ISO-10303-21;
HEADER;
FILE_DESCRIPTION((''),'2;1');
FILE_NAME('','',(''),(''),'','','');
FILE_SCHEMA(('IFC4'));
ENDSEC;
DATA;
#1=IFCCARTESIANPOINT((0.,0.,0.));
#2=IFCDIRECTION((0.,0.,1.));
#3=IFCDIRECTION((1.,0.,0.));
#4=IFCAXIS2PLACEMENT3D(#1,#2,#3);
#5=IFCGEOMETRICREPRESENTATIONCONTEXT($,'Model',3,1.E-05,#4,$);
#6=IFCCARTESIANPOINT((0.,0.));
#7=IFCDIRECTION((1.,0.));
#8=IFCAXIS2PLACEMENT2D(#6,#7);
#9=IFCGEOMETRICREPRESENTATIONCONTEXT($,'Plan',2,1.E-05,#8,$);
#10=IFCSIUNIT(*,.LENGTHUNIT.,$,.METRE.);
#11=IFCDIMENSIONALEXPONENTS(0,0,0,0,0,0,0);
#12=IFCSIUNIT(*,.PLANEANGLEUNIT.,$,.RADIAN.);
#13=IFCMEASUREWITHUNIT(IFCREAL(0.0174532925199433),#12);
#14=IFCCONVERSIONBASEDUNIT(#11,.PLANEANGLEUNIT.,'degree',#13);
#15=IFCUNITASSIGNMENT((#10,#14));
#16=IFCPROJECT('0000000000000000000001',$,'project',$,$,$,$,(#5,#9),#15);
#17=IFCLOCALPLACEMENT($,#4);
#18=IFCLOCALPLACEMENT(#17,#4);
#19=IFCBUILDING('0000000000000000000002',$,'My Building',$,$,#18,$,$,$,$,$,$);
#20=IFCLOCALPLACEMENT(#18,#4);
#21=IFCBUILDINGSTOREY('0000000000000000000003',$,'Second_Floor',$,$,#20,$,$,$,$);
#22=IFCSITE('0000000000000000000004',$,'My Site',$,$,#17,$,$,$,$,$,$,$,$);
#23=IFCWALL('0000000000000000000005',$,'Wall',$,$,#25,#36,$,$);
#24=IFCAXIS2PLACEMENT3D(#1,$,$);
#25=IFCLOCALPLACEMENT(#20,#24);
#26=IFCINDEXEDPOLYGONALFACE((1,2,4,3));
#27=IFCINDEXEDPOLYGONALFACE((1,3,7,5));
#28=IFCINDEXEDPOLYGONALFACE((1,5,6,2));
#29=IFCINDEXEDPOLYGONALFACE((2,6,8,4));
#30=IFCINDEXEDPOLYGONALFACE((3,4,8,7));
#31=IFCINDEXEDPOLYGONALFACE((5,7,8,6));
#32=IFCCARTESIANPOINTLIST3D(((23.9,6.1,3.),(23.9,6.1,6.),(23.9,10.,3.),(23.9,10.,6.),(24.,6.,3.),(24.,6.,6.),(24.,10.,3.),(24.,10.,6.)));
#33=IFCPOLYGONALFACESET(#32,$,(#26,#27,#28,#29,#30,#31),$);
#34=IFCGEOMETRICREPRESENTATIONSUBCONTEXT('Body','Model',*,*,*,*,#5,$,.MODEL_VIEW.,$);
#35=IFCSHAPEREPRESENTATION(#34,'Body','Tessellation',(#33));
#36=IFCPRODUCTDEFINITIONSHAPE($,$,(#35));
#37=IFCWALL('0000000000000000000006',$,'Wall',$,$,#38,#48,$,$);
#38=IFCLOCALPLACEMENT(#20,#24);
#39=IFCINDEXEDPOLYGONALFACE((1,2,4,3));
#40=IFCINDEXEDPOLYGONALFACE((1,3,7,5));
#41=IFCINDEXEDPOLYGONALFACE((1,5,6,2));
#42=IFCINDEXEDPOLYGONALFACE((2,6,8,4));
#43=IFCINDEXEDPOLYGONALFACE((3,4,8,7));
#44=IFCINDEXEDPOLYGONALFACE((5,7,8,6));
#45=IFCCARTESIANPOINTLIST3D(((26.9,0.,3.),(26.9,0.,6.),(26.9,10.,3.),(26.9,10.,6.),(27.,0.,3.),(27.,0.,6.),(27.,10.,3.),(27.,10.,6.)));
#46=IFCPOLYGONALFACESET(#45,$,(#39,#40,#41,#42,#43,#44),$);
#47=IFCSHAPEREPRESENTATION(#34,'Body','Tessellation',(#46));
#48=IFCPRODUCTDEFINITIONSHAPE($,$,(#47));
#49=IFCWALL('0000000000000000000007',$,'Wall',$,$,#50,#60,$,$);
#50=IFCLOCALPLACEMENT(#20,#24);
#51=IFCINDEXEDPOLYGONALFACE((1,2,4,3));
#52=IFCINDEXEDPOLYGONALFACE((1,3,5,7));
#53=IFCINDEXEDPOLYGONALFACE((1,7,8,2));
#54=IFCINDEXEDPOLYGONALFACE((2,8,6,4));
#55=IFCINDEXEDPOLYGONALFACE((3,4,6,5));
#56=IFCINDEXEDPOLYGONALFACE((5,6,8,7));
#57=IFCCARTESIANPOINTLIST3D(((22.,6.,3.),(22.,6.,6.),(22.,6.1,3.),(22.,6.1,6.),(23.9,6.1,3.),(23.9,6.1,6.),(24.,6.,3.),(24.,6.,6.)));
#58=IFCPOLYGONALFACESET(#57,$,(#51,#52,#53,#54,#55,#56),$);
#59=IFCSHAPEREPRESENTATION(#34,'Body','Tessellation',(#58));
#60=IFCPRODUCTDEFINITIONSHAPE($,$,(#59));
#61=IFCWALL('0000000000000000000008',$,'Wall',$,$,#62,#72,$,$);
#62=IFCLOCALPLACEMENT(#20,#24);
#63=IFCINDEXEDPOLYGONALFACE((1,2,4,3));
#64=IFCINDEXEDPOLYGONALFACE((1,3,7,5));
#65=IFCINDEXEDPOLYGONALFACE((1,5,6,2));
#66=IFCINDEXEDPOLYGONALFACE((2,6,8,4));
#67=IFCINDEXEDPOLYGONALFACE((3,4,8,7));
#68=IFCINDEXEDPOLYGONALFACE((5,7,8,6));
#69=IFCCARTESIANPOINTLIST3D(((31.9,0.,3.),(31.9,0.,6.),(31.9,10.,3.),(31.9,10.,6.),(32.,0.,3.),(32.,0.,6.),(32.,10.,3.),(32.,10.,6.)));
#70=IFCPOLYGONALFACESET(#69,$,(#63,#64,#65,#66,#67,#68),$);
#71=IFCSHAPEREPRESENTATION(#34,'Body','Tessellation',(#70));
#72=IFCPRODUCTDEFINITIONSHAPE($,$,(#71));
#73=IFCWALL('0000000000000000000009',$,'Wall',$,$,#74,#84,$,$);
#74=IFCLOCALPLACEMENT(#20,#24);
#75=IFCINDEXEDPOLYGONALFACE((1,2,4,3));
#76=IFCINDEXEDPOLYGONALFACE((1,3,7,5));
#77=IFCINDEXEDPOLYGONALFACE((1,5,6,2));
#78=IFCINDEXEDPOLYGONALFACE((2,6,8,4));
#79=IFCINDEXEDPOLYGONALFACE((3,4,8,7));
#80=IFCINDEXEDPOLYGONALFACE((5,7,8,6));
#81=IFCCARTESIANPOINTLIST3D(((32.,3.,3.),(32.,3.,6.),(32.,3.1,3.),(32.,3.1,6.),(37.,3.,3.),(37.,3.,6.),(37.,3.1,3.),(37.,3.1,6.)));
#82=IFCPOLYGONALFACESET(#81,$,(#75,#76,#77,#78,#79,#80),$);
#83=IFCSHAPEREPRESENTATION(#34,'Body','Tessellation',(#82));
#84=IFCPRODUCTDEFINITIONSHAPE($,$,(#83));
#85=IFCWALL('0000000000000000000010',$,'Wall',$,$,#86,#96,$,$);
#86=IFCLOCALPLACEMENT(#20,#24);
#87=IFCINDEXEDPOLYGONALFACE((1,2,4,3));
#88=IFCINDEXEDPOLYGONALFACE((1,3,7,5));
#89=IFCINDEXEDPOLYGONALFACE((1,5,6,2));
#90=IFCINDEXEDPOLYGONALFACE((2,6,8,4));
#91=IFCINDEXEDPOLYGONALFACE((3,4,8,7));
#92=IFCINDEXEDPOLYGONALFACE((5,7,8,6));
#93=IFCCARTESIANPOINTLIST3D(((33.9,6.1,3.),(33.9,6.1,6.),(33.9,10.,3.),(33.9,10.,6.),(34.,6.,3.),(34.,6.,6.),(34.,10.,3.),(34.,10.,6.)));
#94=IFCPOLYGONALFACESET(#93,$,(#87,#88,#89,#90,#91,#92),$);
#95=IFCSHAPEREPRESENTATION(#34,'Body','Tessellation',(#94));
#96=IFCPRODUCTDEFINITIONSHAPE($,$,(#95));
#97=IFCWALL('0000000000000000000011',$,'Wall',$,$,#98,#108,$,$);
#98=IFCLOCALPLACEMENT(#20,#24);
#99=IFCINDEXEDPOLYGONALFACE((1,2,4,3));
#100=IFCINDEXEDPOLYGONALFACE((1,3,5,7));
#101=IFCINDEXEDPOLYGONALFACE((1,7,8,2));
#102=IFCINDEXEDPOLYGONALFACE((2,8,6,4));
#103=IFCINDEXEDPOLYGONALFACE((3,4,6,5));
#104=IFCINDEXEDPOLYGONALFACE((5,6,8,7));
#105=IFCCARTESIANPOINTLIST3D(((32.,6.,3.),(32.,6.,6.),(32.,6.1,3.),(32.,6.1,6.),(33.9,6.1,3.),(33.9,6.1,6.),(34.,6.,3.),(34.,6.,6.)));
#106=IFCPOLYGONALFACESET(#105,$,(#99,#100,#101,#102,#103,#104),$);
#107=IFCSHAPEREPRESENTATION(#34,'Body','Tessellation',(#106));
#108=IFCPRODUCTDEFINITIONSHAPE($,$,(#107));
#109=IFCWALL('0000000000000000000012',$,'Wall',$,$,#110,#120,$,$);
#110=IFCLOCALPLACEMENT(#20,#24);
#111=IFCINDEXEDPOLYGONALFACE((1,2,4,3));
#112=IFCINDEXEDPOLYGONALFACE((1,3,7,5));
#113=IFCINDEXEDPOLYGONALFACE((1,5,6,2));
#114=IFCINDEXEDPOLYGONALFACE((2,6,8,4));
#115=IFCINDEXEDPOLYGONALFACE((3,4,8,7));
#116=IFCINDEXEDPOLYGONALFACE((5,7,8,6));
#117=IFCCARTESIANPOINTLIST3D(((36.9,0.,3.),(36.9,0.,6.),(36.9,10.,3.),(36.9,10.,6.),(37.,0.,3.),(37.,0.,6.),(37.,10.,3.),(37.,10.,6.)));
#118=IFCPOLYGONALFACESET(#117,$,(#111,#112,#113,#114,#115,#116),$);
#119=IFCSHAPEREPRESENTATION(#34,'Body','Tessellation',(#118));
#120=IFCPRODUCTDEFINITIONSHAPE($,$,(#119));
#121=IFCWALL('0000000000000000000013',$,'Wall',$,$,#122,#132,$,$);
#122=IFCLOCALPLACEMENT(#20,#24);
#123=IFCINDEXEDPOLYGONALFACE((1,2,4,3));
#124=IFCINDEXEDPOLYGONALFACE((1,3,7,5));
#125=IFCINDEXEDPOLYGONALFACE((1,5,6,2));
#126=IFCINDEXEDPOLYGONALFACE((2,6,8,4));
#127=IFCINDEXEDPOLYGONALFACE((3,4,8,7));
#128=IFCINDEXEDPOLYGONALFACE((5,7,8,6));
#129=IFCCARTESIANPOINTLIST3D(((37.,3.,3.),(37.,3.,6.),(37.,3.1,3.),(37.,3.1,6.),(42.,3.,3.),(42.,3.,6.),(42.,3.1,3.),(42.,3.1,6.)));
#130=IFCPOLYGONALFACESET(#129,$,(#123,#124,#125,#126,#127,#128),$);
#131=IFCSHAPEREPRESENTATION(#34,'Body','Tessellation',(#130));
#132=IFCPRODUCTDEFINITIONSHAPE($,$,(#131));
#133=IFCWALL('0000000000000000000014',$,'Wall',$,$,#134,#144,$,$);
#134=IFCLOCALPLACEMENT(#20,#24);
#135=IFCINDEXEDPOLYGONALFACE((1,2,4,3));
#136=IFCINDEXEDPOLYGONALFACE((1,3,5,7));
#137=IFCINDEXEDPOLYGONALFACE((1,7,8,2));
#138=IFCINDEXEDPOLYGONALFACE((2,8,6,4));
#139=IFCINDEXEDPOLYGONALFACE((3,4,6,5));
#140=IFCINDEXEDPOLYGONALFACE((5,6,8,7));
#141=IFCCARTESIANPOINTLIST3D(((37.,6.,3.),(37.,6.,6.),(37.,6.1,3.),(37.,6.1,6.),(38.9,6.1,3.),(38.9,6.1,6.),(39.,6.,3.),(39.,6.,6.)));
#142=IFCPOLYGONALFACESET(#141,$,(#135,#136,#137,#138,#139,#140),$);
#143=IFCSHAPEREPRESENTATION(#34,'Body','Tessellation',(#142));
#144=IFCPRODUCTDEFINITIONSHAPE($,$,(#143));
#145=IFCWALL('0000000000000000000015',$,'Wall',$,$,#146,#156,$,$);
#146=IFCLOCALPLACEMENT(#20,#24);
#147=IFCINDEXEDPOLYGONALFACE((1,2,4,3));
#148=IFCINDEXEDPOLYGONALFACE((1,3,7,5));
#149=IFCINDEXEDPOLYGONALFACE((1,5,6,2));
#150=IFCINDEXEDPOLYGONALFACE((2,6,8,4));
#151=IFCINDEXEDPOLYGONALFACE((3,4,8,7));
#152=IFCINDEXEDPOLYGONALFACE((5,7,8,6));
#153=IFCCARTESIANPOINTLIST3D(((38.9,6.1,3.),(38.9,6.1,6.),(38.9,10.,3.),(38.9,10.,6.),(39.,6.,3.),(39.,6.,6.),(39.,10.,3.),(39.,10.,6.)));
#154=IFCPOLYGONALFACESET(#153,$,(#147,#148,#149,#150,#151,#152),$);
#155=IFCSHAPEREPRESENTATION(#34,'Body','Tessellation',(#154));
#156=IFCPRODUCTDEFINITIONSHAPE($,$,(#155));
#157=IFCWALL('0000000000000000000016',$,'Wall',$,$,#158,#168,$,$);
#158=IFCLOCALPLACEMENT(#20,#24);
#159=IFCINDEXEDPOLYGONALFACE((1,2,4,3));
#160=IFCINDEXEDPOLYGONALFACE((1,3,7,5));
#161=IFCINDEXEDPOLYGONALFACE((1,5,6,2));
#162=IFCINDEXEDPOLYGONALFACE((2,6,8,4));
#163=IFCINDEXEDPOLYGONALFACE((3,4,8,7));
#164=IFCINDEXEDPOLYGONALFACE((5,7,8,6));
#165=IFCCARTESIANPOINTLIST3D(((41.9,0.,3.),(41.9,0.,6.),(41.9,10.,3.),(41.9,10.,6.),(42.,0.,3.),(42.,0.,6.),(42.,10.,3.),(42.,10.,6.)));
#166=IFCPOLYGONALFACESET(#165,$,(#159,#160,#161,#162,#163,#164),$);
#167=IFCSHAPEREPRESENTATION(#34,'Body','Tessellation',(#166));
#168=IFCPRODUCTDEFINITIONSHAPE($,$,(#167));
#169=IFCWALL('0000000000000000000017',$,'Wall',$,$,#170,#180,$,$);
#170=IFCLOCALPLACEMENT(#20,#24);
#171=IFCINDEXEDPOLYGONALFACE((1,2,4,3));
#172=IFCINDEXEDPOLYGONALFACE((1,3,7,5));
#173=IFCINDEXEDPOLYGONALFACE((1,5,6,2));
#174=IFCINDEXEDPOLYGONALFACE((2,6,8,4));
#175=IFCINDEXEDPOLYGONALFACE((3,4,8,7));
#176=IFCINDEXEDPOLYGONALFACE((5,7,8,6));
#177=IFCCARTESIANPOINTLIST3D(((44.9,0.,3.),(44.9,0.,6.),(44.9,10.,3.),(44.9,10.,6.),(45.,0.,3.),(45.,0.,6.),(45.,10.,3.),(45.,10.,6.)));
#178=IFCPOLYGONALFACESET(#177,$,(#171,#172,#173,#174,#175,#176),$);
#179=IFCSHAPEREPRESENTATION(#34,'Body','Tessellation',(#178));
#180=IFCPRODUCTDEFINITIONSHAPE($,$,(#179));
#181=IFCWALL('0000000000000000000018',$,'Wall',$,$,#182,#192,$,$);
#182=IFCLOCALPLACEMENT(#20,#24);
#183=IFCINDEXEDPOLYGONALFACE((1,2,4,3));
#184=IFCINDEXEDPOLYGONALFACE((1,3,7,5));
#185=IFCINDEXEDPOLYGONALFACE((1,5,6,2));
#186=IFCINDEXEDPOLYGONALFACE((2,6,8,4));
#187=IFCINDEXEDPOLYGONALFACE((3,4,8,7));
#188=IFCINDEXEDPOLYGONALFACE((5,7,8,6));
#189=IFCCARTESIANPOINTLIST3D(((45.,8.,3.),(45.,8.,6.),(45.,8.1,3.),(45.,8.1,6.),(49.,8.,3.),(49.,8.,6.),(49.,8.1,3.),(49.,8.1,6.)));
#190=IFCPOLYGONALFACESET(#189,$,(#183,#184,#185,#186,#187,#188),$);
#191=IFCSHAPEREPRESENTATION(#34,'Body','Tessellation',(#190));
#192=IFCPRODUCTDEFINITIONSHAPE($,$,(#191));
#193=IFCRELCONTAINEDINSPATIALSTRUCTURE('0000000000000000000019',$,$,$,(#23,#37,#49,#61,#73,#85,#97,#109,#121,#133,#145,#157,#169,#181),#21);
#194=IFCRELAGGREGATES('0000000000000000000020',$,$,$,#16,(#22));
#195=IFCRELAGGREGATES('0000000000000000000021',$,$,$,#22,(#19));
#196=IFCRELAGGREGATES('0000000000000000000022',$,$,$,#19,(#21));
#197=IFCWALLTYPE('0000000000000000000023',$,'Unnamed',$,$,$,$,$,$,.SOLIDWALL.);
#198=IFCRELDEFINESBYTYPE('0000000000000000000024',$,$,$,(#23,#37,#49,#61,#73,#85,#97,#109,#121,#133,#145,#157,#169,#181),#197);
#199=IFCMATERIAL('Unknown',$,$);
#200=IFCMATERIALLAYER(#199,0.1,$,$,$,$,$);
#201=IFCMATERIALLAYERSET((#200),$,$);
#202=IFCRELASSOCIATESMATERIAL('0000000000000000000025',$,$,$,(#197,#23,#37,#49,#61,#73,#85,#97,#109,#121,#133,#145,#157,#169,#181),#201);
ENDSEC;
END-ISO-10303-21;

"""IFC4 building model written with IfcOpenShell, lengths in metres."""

from ifc_helpers import new_model, entity, si_unit, converted_unit, frame, origin_with_axes, origin_2d_with_axis, place, context, subcontext, project, spatial, line, indexed_curve, outline, extrude, material, layer, layer_set, layer_usage, type_object, element, save


model = new_model("IFC4")

# Units and contexts
model_context = context("Model", 3, precision=1e-05, world=origin_with_axes())
plan_context = context("Plan", 2, precision=1e-05, world=origin_2d_with_axis())
body_context = subcontext(model_context, "Body", "Model", "MODEL_VIEW")
ifc_project = project(units=[si_unit("LENGTHUNIT", "METRE"), converted_unit("PLANEANGLEUNIT", "degree", entity("IfcReal", 0.0174532925199433), si_unit("PLANEANGLEUNIT", "RADIAN"), dimensions=[0, 0, 0, 0, 0, 0, 0])], contexts=[model_context, plan_context])

# Site, building, storey
site_placement = place(None, origin_with_axes())
site = spatial("IfcSite", under=ifc_project, at=site_placement, Name="My Site")
building_placement = place(site_placement, origin_with_axes())
building = spatial("IfcBuilding", under=site, at=building_placement, Name="My Building")
storey_placement = place(building_placement, origin_with_axes())
storey = spatial("IfcBuildingStorey", under=building, at=storey_placement, Name="Second_Floor")

# Walls
ifc_material = material(Name="Unknown")
ifc_layer = layer(ifc_material, 0.1)
ifc_layer_set = layer_set([ifc_layer])
ifc_layer_usage_1 = layer_usage(ifc_layer_set, "AXIS2", "POSITIVE", 0.0)
wall_type = type_object("IfcWallType", Name="Unnamed", PredefinedType="SOLIDWALL", material=ifc_layer_set)
wall_1_placement = place(storey_placement, frame((24.0, 6.0, 3.0), z_axis=(0.0, 0.0, 1.0), x_axis=(0.0, 1.0, 0.0)))
element("IfcWall", 1, at=wall_1_placement, inside=storey, type_object=wall_type, material=ifc_layer_usage_1, Name="Wall", context=body_context, shape_type="SweptSolid", body=[
    extrude(outline(indexed_curve([(0.0, 0.0), (0.1, 0.1), (4.0, 0.1), (4.0, 0.0)], segments=[line(1, 2, 3, 4, 1)])), origin_with_axes(), (0.0, 0.0, 1.0), 3.0),
])
ifc_layer_usage_2 = layer_usage(ifc_layer_set, "AXIS2", "POSITIVE", 0.0)
wall_2_placement = place(storey_placement, frame((26.9, 10.0, 3.0), z_axis=(0.0, 0.0, 1.0), x_axis=(0.0, -1.0, 0.0)))
element("IfcWall", 2, at=wall_2_placement, inside=storey, type_object=wall_type, material=ifc_layer_usage_2, Name="Wall", context=body_context, shape_type="SweptSolid", body=[
    extrude(outline(indexed_curve([(0.0, 0.0), (0.0, 0.1), (10.0, 0.1), (10.0, 0.0)], segments=[line(1, 2, 3, 4, 1)])), origin_with_axes(), (0.0, 0.0, 1.0), 3.0),
])
ifc_layer_usage_3 = layer_usage(ifc_layer_set, "AXIS2", "POSITIVE", 0.0)
wall_3_placement = place(storey_placement, frame((22.0, 6.0, 3.0), z_axis=(0.0, 0.0, 1.0), x_axis=(1.0, 0.0, 0.0)))
element("IfcWall", 3, at=wall_3_placement, inside=storey, type_object=wall_type, material=ifc_layer_usage_3, Name="Wall", context=body_context, shape_type="SweptSolid", body=[
    extrude(outline(indexed_curve([(0.0, 0.0), (0.0, 0.1), (1.9, 0.1), (2.0, 0.0)], segments=[line(1, 2, 3, 4, 1)])), origin_with_axes(), (0.0, 0.0, 1.0), 3.0),
])
ifc_layer_usage_4 = layer_usage(ifc_layer_set, "AXIS2", "POSITIVE", 0.0)
wall_4_placement = place(storey_placement, frame((31.9, 10.0, 3.0), z_axis=(0.0, 0.0, 1.0), x_axis=(0.0, -1.0, 0.0)))
element("IfcWall", 4, at=wall_4_placement, inside=storey, type_object=wall_type, material=ifc_layer_usage_4, Name="Wall", context=body_context, shape_type="SweptSolid", body=[
    extrude(outline(indexed_curve([(0.0, 0.0), (0.0, 0.1), (10.0, 0.1), (10.0, 0.0)], segments=[line(1, 2, 3, 4, 1)])), origin_with_axes(), (0.0, 0.0, 1.0), 3.0),
])
ifc_layer_usage_5 = layer_usage(ifc_layer_set, "AXIS2", "POSITIVE", 0.0)
wall_5_placement = place(storey_placement, frame((32.0, 3.0, 3.0), z_axis=(0.0, 0.0, 1.0), x_axis=(1.0, 0.0, 0.0)))
element("IfcWall", 5, at=wall_5_placement, inside=storey, type_object=wall_type, material=ifc_layer_usage_5, Name="Wall", context=body_context, shape_type="SweptSolid", body=[
    extrude(outline(indexed_curve([(0.0, 0.0), (0.0, 0.1), (5.0, 0.1), (5.0, 0.0)], segments=[line(1, 2, 3, 4, 1)])), origin_with_axes(), (0.0, 0.0, 1.0), 3.0),
])
ifc_layer_usage_6 = layer_usage(ifc_layer_set, "AXIS2", "POSITIVE", 0.0)
wall_6_placement = place(storey_placement, frame((34.0, 6.0, 3.0), z_axis=(0.0, 0.0, 1.0), x_axis=(0.0, 1.0, 0.0)))
element("IfcWall", 6, at=wall_6_placement, inside=storey, type_object=wall_type, material=ifc_layer_usage_6, Name="Wall", context=body_context, shape_type="SweptSolid", body=[
    extrude(outline(indexed_curve([(0.0, 0.0), (0.1, 0.1), (4.0, 0.1), (4.0, 0.0)], segments=[line(1, 2, 3, 4, 1)])), origin_with_axes(), (0.0, 0.0, 1.0), 3.0),
])
ifc_layer_usage_7 = layer_usage(ifc_layer_set, "AXIS2", "POSITIVE", 0.0)
wall_7_placement = place(storey_placement, frame((32.0, 6.0, 3.0), z_axis=(0.0, 0.0, 1.0), x_axis=(1.0, 0.0, 0.0)))
element("IfcWall", 7, at=wall_7_placement, inside=storey, type_object=wall_type, material=ifc_layer_usage_7, Name="Wall", context=body_context, shape_type="SweptSolid", body=[
    extrude(outline(indexed_curve([(0.0, 0.0), (0.0, 0.1), (1.9, 0.1), (2.0, 0.0)], segments=[line(1, 2, 3, 4, 1)])), origin_with_axes(), (0.0, 0.0, 1.0), 3.0),
])
ifc_layer_usage_8 = layer_usage(ifc_layer_set, "AXIS2", "POSITIVE", 0.0)
wall_8_placement = place(storey_placement, frame((36.9, 10.0, 3.0), z_axis=(0.0, 0.0, 1.0), x_axis=(0.0, -1.0, 0.0)))
element("IfcWall", 8, at=wall_8_placement, inside=storey, type_object=wall_type, material=ifc_layer_usage_8, Name="Wall", context=body_context, shape_type="SweptSolid", body=[
    extrude(outline(indexed_curve([(0.0, 0.0), (0.0, 0.1), (10.0, 0.1), (10.0, 0.0)], segments=[line(1, 2, 3, 4, 1)])), origin_with_axes(), (0.0, 0.0, 1.0), 3.0),
])
ifc_layer_usage_9 = layer_usage(ifc_layer_set, "AXIS2", "POSITIVE", 0.0)
wall_9_placement = place(storey_placement, frame((37.0, 3.0, 3.0), z_axis=(0.0, 0.0, 1.0), x_axis=(1.0, 0.0, 0.0)))
element("IfcWall", 9, at=wall_9_placement, inside=storey, type_object=wall_type, material=ifc_layer_usage_9, Name="Wall", context=body_context, shape_type="SweptSolid", body=[
    extrude(outline(indexed_curve([(0.0, 0.0), (0.0, 0.1), (5.0, 0.1), (5.0, 0.0)], segments=[line(1, 2, 3, 4, 1)])), origin_with_axes(), (0.0, 0.0, 1.0), 3.0),
])
ifc_layer_usage_10 = layer_usage(ifc_layer_set, "AXIS2", "POSITIVE", 0.0)
wall_10_placement = place(storey_placement, frame((37.0, 6.0, 3.0), z_axis=(0.0, 0.0, 1.0), x_axis=(1.0, 0.0, 0.0)))
element("IfcWall", 10, at=wall_10_placement, inside=storey, type_object=wall_type, material=ifc_layer_usage_10, Name="Wall", context=body_context, shape_type="SweptSolid", body=[
    extrude(outline(indexed_curve([(0.0, 0.0), (0.0, 0.1), (1.9, 0.1), (2.0, 0.0)], segments=[line(1, 2, 3, 4, 1)])), origin_with_axes(), (0.0, 0.0, 1.0), 3.0),
])
ifc_layer_usage_11 = layer_usage(ifc_layer_set, "AXIS2", "POSITIVE", 0.0)
wall_11_placement = place(storey_placement, frame((39.0, 6.0, 3.0), z_axis=(0.0, 0.0, 1.0), x_axis=(0.0, 1.0, 0.0)))
element("IfcWall", 11, at=wall_11_placement, inside=storey, type_object=wall_type, material=ifc_layer_usage_11, Name="Wall", context=body_context, shape_type="SweptSolid", body=[
    extrude(outline(indexed_curve([(0.0, 0.0), (0.1, 0.1), (4.0, 0.1), (4.0, 0.0)], segments=[line(1, 2, 3, 4, 1)])), origin_with_axes(), (0.0, 0.0, 1.0), 3.0),
])
ifc_layer_usage_12 = layer_usage(ifc_layer_set, "AXIS2", "POSITIVE", 0.0)
wall_12_placement = place(storey_placement, frame((41.9, 10.0, 3.0), z_axis=(0.0, 0.0, 1.0), x_axis=(0.0, -1.0, 0.0)))
element("IfcWall", 12, at=wall_12_placement, inside=storey, type_object=wall_type, material=ifc_layer_usage_12, Name="Wall", context=body_context, shape_type="SweptSolid", body=[
    extrude(outline(indexed_curve([(0.0, 0.0), (0.0, 0.1), (10.0, 0.1), (10.0, 0.0)], segments=[line(1, 2, 3, 4, 1)])), origin_with_axes(), (0.0, 0.0, 1.0), 3.0),
])
ifc_layer_usage_13 = layer_usage(ifc_layer_set, "AXIS2", "POSITIVE", 0.0)
wall_13_placement = place(storey_placement, frame((44.9, 10.0, 3.0), z_axis=(0.0, 0.0, 1.0), x_axis=(0.0, -1.0, 0.0)))
element("IfcWall", 13, at=wall_13_placement, inside=storey, type_object=wall_type, material=ifc_layer_usage_13, Name="Wall", context=body_context, shape_type="SweptSolid", body=[
    extrude(outline(indexed_curve([(0.0, 0.0), (0.0, 0.1), (10.0, 0.1), (10.0, 0.0)], segments=[line(1, 2, 3, 4, 1)])), origin_with_axes(), (0.0, 0.0, 1.0), 3.0),
])
ifc_layer_usage_14 = layer_usage(ifc_layer_set, "AXIS2", "POSITIVE", 0.0)
wall_14_placement = place(storey_placement, frame((45.0, 8.0, 3.0), z_axis=(0.0, 0.0, 1.0), x_axis=(1.0, 0.0, 0.0)))
element("IfcWall", 14, at=wall_14_placement, inside=storey, type_object=wall_type, material=ifc_layer_usage_14, Name="Wall", context=body_context, shape_type="SweptSolid", body=[
    extrude(outline(indexed_curve([(0.0, 0.0), (0.0, 0.1), (4.0, 0.1), (4.0, 0.0)], segments=[line(1, 2, 3, 4, 1)])), origin_with_axes(), (0.0, 0.0, 1.0), 3.0),
])

save(model, "model.ifc")
